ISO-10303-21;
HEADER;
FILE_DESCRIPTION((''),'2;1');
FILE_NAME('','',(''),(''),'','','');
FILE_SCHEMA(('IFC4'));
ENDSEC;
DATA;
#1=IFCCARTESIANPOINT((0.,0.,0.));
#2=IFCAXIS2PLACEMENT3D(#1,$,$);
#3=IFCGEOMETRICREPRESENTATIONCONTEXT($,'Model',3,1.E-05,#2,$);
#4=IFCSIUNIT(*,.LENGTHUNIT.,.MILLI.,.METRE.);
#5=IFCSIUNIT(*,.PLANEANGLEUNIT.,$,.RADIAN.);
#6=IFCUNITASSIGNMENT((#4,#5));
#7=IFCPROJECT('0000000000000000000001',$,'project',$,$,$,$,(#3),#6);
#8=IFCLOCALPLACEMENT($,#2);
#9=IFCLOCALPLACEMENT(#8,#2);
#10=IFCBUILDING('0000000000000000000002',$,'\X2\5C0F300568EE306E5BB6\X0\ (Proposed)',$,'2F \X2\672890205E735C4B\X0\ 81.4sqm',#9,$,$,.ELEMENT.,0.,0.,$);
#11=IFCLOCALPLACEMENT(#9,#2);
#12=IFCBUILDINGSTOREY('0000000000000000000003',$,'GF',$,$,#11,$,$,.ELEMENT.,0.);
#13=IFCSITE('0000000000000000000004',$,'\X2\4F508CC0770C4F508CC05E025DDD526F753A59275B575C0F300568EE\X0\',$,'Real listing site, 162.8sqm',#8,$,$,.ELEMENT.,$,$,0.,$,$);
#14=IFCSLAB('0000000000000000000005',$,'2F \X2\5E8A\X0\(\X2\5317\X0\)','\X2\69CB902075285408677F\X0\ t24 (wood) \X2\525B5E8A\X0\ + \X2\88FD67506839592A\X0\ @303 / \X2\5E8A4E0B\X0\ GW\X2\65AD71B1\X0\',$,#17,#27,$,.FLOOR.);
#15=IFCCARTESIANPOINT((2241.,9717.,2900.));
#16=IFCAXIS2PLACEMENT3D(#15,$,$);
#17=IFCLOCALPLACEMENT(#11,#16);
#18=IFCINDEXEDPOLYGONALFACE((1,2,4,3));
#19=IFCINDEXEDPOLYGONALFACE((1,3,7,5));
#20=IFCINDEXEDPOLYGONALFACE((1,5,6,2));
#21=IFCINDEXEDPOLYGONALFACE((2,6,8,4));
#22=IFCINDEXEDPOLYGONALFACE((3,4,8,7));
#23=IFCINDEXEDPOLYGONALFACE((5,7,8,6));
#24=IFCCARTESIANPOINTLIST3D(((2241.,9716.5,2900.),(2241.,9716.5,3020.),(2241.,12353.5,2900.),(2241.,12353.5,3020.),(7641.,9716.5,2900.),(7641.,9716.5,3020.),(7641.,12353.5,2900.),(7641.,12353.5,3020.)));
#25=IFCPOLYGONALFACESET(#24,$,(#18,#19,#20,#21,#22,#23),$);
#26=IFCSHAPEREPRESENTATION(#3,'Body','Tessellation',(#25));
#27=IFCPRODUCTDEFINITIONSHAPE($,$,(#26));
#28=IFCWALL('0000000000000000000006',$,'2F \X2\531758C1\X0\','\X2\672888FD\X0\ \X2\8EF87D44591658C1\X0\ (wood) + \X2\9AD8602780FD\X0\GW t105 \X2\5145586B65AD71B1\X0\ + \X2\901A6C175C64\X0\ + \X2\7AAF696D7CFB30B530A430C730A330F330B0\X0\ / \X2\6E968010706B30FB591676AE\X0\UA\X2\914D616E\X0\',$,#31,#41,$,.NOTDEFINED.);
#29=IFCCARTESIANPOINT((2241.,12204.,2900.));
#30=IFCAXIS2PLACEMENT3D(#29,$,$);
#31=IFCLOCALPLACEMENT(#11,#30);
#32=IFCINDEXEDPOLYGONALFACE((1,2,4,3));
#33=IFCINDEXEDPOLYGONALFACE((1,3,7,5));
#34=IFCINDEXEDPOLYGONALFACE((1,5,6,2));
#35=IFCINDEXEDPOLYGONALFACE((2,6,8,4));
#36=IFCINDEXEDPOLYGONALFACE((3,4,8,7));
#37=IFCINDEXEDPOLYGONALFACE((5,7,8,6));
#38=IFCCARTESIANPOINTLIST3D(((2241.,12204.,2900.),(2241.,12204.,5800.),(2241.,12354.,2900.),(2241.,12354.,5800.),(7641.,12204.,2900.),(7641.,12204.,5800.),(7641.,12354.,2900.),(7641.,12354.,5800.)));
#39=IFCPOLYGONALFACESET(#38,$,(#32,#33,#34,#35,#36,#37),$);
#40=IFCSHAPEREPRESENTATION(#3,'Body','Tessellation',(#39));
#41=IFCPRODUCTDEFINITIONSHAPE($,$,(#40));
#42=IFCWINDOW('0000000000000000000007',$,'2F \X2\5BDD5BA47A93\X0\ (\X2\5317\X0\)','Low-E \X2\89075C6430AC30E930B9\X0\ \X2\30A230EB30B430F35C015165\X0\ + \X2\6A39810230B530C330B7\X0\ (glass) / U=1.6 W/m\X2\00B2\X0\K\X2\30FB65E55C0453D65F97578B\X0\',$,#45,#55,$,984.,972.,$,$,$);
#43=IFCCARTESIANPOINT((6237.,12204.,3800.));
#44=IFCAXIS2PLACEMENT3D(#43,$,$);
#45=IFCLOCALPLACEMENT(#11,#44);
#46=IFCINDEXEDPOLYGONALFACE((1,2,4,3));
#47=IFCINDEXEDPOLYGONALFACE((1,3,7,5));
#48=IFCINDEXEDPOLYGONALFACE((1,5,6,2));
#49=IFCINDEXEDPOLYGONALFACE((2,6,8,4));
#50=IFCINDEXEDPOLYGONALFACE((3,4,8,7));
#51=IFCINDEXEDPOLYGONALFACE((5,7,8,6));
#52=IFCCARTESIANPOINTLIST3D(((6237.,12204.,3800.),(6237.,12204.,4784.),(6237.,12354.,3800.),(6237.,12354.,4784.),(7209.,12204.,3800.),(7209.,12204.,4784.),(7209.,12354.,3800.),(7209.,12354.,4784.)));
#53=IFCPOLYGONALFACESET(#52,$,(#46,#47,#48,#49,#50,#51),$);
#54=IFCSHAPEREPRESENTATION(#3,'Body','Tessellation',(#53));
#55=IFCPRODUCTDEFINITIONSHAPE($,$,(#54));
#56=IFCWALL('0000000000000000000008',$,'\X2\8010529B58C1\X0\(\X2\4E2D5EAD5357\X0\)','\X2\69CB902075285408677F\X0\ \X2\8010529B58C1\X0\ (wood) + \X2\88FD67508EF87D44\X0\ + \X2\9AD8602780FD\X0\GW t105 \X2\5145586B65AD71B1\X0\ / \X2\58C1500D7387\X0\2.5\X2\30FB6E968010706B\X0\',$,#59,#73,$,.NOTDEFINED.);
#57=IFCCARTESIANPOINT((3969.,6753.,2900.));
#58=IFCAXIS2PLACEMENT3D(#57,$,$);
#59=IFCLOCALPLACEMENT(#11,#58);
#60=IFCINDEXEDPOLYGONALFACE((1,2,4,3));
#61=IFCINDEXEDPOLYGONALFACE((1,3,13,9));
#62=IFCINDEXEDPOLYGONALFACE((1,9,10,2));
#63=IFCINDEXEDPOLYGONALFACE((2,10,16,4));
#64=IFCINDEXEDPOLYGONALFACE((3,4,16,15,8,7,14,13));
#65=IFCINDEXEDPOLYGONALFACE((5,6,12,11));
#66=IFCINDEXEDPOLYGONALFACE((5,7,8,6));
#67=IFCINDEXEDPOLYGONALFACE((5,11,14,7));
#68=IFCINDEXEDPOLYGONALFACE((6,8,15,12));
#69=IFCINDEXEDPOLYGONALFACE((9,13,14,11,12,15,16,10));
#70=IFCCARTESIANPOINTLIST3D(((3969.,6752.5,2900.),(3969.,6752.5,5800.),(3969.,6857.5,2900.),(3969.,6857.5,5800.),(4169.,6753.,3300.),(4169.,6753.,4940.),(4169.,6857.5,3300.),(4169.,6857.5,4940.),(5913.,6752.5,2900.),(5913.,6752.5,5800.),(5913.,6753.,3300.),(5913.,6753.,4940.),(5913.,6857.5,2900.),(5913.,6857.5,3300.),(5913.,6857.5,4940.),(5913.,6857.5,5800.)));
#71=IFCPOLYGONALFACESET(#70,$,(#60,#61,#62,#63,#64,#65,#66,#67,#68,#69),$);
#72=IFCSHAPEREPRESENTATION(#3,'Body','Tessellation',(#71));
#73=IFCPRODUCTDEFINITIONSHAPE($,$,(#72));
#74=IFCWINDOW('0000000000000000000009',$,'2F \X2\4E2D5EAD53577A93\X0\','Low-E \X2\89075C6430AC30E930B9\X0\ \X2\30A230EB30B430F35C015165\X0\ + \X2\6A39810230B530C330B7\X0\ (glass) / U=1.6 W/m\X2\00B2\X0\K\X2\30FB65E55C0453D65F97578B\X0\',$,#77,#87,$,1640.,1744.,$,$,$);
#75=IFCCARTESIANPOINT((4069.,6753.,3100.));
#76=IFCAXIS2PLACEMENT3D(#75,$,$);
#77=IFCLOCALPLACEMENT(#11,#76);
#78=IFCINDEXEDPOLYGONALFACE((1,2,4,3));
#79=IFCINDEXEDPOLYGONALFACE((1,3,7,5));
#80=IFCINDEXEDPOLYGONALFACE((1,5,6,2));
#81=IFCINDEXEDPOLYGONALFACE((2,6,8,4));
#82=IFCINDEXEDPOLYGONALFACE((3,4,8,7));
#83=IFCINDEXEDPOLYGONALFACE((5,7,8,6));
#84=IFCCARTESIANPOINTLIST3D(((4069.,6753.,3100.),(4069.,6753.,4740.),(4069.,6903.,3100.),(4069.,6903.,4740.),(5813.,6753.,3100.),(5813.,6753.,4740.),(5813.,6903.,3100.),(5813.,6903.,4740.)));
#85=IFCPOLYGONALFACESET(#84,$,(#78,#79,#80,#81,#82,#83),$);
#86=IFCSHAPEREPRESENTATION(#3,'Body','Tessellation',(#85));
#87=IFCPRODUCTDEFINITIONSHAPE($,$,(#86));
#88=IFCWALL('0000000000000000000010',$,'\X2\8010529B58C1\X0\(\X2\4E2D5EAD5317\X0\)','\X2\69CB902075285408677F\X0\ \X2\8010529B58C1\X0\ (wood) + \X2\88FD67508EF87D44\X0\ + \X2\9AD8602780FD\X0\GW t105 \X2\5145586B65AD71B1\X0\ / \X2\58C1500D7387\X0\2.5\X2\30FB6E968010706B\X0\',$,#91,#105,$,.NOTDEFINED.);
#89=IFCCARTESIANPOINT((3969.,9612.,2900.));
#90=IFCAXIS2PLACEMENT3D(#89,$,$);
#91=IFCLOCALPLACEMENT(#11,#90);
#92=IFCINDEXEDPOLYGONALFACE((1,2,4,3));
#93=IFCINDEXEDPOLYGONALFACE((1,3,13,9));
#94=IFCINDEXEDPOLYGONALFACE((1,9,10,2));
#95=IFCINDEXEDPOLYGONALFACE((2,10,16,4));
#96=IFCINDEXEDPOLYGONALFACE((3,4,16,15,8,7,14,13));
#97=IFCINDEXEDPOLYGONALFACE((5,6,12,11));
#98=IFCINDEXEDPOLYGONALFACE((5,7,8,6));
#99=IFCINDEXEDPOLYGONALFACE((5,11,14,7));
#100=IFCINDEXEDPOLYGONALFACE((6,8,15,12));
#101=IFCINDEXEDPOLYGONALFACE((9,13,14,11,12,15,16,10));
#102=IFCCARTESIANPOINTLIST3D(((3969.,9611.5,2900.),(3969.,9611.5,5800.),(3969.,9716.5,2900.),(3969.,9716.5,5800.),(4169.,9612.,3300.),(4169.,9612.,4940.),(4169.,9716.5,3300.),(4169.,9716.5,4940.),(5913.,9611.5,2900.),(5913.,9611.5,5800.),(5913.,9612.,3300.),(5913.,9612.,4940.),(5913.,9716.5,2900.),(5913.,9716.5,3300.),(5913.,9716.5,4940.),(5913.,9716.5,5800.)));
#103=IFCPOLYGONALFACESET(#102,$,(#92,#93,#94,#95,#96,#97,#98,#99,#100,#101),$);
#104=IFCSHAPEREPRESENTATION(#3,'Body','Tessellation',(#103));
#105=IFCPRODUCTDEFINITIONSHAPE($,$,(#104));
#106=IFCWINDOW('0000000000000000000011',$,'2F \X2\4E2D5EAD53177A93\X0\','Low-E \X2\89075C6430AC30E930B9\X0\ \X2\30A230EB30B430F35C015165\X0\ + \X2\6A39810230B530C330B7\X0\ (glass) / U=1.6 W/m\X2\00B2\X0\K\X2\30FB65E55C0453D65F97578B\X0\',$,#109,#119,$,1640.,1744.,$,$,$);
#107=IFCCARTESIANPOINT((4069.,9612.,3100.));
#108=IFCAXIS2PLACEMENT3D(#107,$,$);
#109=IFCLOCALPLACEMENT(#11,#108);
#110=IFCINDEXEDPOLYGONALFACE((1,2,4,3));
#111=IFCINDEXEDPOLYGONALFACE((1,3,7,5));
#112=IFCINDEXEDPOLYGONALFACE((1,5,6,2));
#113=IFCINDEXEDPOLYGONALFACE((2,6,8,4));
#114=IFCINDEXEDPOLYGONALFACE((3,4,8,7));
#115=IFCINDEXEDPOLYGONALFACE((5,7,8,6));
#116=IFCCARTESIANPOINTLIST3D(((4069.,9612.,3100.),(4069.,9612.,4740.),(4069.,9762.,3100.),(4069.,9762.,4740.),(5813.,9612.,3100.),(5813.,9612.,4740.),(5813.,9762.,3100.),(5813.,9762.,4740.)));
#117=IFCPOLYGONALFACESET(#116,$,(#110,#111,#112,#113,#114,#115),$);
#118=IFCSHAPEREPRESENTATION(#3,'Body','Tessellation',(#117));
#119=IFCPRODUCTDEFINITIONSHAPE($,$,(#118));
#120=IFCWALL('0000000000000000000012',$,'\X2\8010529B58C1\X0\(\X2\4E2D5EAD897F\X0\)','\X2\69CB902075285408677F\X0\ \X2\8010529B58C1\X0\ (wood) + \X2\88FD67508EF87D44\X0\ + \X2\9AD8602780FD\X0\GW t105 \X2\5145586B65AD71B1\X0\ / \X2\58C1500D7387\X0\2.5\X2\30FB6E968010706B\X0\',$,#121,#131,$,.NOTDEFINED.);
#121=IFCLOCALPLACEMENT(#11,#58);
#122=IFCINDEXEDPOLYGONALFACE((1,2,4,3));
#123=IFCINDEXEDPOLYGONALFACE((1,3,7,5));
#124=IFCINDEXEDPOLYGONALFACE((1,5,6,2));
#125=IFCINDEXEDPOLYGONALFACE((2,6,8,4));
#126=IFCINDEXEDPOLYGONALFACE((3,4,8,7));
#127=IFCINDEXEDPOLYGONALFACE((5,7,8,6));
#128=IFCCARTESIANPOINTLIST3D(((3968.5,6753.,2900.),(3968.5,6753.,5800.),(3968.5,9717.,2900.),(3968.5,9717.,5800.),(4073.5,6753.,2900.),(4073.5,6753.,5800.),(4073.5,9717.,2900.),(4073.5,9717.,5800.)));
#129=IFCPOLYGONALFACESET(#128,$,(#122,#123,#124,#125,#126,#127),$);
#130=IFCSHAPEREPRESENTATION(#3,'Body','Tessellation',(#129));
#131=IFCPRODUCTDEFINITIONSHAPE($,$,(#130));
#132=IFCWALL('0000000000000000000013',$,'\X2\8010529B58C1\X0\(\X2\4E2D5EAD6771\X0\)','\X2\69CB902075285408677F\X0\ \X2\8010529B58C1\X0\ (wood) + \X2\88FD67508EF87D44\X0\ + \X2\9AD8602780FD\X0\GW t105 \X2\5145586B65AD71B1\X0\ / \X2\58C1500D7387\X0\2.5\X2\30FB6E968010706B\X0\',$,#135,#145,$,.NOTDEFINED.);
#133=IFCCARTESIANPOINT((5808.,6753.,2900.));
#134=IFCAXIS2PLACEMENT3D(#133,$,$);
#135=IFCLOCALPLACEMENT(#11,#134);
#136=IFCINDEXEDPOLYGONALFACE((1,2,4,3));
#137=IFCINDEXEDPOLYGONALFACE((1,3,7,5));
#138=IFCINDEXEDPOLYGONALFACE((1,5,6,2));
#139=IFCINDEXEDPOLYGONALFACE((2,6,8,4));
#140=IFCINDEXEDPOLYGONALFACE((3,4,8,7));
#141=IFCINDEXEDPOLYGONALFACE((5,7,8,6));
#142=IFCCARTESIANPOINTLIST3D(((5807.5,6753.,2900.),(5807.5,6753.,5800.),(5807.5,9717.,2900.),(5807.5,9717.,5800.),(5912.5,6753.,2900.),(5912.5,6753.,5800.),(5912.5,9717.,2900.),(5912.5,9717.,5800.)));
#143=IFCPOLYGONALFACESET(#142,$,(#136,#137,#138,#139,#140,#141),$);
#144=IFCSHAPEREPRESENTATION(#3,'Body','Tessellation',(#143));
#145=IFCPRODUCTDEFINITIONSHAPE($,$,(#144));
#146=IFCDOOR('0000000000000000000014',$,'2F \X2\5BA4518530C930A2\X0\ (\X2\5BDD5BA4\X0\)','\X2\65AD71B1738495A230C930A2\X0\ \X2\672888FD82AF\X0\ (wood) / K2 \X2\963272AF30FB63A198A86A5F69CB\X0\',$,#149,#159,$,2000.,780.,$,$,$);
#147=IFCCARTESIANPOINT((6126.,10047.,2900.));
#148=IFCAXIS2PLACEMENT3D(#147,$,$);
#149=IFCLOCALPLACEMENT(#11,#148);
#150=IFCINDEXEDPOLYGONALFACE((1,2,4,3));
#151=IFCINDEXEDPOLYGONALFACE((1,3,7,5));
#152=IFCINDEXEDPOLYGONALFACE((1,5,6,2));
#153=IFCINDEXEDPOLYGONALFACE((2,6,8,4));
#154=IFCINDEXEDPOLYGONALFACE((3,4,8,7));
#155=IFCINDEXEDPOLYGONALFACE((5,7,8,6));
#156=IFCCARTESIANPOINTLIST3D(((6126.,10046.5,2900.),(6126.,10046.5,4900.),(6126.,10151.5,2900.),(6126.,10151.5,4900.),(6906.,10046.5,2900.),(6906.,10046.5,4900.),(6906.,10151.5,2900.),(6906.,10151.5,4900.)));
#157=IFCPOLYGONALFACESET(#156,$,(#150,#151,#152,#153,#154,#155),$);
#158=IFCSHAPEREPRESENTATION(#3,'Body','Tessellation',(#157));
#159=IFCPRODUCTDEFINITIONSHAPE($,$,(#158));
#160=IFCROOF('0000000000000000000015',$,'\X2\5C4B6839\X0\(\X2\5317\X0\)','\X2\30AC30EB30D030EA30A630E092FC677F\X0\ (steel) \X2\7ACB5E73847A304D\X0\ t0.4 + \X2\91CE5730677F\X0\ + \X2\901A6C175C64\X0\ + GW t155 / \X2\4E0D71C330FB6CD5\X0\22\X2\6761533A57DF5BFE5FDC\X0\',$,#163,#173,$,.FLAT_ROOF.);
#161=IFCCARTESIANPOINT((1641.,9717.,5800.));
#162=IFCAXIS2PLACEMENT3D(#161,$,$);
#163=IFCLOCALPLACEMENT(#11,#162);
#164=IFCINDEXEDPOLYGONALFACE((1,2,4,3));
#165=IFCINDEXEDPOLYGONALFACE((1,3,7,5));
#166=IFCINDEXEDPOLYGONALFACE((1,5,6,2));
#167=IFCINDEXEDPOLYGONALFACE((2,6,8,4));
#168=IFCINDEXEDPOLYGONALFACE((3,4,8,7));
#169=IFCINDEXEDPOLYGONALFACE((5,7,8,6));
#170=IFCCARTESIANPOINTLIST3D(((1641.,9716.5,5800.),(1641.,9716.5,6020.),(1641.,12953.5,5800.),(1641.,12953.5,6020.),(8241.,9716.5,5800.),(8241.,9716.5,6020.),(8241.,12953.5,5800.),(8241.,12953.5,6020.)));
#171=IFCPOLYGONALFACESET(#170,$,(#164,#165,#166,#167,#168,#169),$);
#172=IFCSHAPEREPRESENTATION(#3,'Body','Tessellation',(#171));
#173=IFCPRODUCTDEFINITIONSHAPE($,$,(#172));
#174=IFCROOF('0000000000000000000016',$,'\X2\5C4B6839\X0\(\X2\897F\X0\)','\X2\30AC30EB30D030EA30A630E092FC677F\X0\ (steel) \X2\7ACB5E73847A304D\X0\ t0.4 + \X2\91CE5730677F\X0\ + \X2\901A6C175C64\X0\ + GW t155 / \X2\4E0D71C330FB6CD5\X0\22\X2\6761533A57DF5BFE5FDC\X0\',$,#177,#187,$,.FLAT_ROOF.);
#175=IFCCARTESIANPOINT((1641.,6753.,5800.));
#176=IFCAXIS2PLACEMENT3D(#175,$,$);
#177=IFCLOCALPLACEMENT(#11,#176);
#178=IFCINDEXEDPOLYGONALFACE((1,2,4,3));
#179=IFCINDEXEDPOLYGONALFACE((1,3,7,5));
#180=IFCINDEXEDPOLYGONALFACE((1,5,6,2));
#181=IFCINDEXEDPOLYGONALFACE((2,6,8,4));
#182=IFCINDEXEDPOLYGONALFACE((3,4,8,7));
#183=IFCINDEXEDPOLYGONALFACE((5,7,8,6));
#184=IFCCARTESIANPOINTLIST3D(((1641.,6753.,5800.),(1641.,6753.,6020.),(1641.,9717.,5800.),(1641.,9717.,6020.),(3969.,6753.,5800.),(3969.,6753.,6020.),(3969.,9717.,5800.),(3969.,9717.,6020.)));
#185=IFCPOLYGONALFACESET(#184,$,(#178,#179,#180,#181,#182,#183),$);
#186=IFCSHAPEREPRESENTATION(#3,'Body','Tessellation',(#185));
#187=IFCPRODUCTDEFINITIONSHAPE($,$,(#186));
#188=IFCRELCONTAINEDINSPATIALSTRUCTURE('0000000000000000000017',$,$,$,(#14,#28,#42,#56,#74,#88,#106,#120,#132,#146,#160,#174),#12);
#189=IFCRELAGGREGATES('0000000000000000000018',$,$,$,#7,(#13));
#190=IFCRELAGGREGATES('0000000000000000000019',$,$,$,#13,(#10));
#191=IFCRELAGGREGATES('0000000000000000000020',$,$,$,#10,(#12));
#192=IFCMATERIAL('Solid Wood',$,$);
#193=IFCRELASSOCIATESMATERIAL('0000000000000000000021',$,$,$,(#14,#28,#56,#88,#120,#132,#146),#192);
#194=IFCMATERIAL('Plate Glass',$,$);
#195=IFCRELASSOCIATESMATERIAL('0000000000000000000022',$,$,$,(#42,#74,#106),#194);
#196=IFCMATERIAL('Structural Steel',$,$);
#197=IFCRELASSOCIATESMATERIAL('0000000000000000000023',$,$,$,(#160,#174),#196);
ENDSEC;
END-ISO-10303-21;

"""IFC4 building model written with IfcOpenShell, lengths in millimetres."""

from ifc_helpers import new_model, si_unit, frame, frame_2d, origin, place, context, project, spatial, rectangle, extrude, material, element, fill, save


model = new_model("IFC4")

# Units and contexts
model_context = context("Model", 3, precision=1e-05, world=origin())
ifc_project = project(units=[si_unit("LENGTHUNIT", "METRE", prefix="MILLI"), si_unit("PLANEANGLEUNIT", "RADIAN")], contexts=[model_context])

# Site, building, storey
site_placement = place(None, origin())
site = spatial("IfcSite", under=ifc_project, at=site_placement, Name="佐賀県佐賀市川副町大字小々森", ObjectType="Real listing site, 162.8sqm", CompositionType="ELEMENT", RefElevation=0.0)
building_placement = place(site_placement, origin())
building = spatial("IfcBuilding", under=site, at=building_placement, Name="小々森の家 (Proposed)", ObjectType="2F 木造平屋 81.4sqm", CompositionType="ELEMENT", ElevationOfRefHeight=0.0, ElevationOfTerrain=0.0)
storey_placement = place(building_placement, origin())
storey = spatial("IfcBuildingStorey", under=building, at=storey_placement, Name="GF", CompositionType="ELEMENT", Elevation=0.0)

# Slab
ifc_material_1 = material(Name="Solid Wood")
slab_placement = place(storey_placement, frame((2241.0, 9717.0, 2900.0)))
element("IfcSlab", 1, at=slab_placement, inside=storey, material=ifc_material_1, Name="2F 床(北)", Description="構造用合板 t24 (wood) 剛床 + 製材根太 @303 / 床下 GW断熱", PredefinedType="FLOOR", context=model_context, shape_type="SweptSolid", body=[
    extrude(rectangle(XDim=5400.0, YDim=2637.0, at=frame_2d((2700.0, 1318.0))), frame((2241.0, 9717.0, 2900.0)), (0.0, 0.0, 1.0), 120.0),
])

# Walls, openings, windows
wall_1_placement = place(storey_placement, frame((2241.0, 12204.0, 2900.0)))
wall_1 = element("IfcWall", 2, at=wall_1_placement, inside=storey, material=ifc_material_1, Name="2F 北壁", Description="木製 軸組外壁 (wood) + 高性能GW t105 充填断熱 + 通気層 + 窯業系サイディング / 準耐火・外皮UA配慮", PredefinedType="NOTDEFINED", context=model_context, shape_type="SweptSolid", body=[
    extrude(rectangle(XDim=5400.0, YDim=150.0, at=frame_2d((2700.0, 75.0))), frame((2241.0, 12204.0, 2900.0)), (0.0, 0.0, 1.0), 2900.0),
])
opening_1_placement = place(storey_placement, frame((6237.0, 12204.0, 3800.0)))
opening_1 = element("IfcOpeningElement", 3, at=opening_1_placement, cuts=wall_1, PredefinedType="NOTDEFINED", context=model_context, shape_type="SweptSolid", body=[
    extrude(rectangle(XDim=972.0, YDim=150.0, at=frame_2d((486.0, 75.0))), frame((6237.0, 12204.0, 3800.0)), (0.0, 0.0, 1.0), 984.0),
])
ifc_material_2 = material(Name="Plate Glass")
window_1_placement = place(storey_placement, frame((6237.0, 12204.0, 3800.0)))
window_1 = element("IfcWindow", 4, at=window_1_placement, inside=storey, material=ifc_material_2, Name="2F 寝室窓 (北)", Description="Low-E 複層ガラス アルゴン封入 + 樹脂サッシ (glass) / U=1.6 W/m²K・日射取得型", OverallHeight=984.0, OverallWidth=972.0, context=model_context, shape_type="SweptSolid", body=[
    extrude(rectangle(XDim=972.0, YDim=150.0, at=frame_2d((486.0, 75.0))), frame((6237.0, 12204.0, 3800.0)), (0.0, 0.0, 1.0), 984.0),
])
fill(opening_1, window_1)
wall_2_placement = place(storey_placement, frame((3969.0, 6753.0, 2900.0)))
wall_2 = element("IfcWall", 5, at=wall_2_placement, inside=storey, material=ifc_material_1, Name="耐力壁(中庭南)", Description="構造用合板 耐力壁 (wood) + 製材軸組 + 高性能GW t105 充填断熱 / 壁倍率2.5・準耐火", PredefinedType="NOTDEFINED", context=model_context, shape_type="SweptSolid", body=[
    extrude(rectangle(XDim=1944.0, YDim=105.0, at=frame_2d((972.0, 52.0))), frame((3969.0, 6753.0, 2900.0)), (0.0, 0.0, 1.0), 2900.0),
])
opening_2_placement = place(storey_placement, frame((4069.0, 6753.0, 3100.0)))
opening_2 = element("IfcOpeningElement", 6, at=opening_2_placement, cuts=wall_2, PredefinedType="NOTDEFINED", context=model_context, shape_type="SweptSolid", body=[
    extrude(rectangle(XDim=1744.0, YDim=150.0, at=frame_2d((872.0, 75.0))), frame((4069.0, 6753.0, 3100.0)), (0.0, 0.0, 1.0), 1640.0),
])
window_2_placement = place(storey_placement, frame((4069.0, 6753.0, 3100.0)))
window_2 = element("IfcWindow", 7, at=window_2_placement, inside=storey, material=ifc_material_2, Name="2F 中庭南窓", Description="Low-E 複層ガラス アルゴン封入 + 樹脂サッシ (glass) / U=1.6 W/m²K・日射取得型", OverallHeight=1640.0, OverallWidth=1744.0, context=model_context, shape_type="SweptSolid", body=[
    extrude(rectangle(XDim=1744.0, YDim=150.0, at=frame_2d((872.0, 75.0))), frame((4069.0, 6753.0, 3100.0)), (0.0, 0.0, 1.0), 1640.0),
])
fill(opening_2, window_2)
wall_3_placement = place(storey_placement, frame((3969.0, 9612.0, 2900.0)))
wall_3 = element("IfcWall", 8, at=wall_3_placement, inside=storey, material=ifc_material_1, Name="耐力壁(中庭北)", Description="構造用合板 耐力壁 (wood) + 製材軸組 + 高性能GW t105 充填断熱 / 壁倍率2.5・準耐火", PredefinedType="NOTDEFINED", context=model_context, shape_type="SweptSolid", body=[
    extrude(rectangle(XDim=1944.0, YDim=105.0, at=frame_2d((972.0, 52.0))), frame((3969.0, 9612.0, 2900.0)), (0.0, 0.0, 1.0), 2900.0),
])
opening_3_placement = place(storey_placement, frame((4069.0, 9612.0, 3100.0)))
opening_3 = element("IfcOpeningElement", 9, at=opening_3_placement, cuts=wall_3, PredefinedType="NOTDEFINED", context=model_context, shape_type="SweptSolid", body=[
    extrude(rectangle(XDim=1744.0, YDim=150.0, at=frame_2d((872.0, 75.0))), frame((4069.0, 9612.0, 3100.0)), (0.0, 0.0, 1.0), 1640.0),
])
window_3_placement = place(storey_placement, frame((4069.0, 9612.0, 3100.0)))
window_3 = element("IfcWindow", 10, at=window_3_placement, inside=storey, material=ifc_material_2, Name="2F 中庭北窓", Description="Low-E 複層ガラス アルゴン封入 + 樹脂サッシ (glass) / U=1.6 W/m²K・日射取得型", OverallHeight=1640.0, OverallWidth=1744.0, context=model_context, shape_type="SweptSolid", body=[
    extrude(rectangle(XDim=1744.0, YDim=150.0, at=frame_2d((872.0, 75.0))), frame((4069.0, 9612.0, 3100.0)), (0.0, 0.0, 1.0), 1640.0),
])
fill(opening_3, window_3)

# Walls
wall_4_placement = place(storey_placement, frame((3969.0, 6753.0, 2900.0)))
element("IfcWall", 11, at=wall_4_placement, inside=storey, material=ifc_material_1, Name="耐力壁(中庭西)", Description="構造用合板 耐力壁 (wood) + 製材軸組 + 高性能GW t105 充填断熱 / 壁倍率2.5・準耐火", PredefinedType="NOTDEFINED", context=model_context, shape_type="SweptSolid", body=[
    extrude(rectangle(XDim=105.0, YDim=2964.0, at=frame_2d((52.0, 1482.0))), frame((3969.0, 6753.0, 2900.0)), (0.0, 0.0, 1.0), 2900.0),
])
wall_5_placement = place(storey_placement, frame((5808.0, 6753.0, 2900.0)))
element("IfcWall", 12, at=wall_5_placement, inside=storey, material=ifc_material_1, Name="耐力壁(中庭東)", Description="構造用合板 耐力壁 (wood) + 製材軸組 + 高性能GW t105 充填断熱 / 壁倍率2.5・準耐火", PredefinedType="NOTDEFINED", context=model_context, shape_type="SweptSolid", body=[
    extrude(rectangle(XDim=105.0, YDim=2964.0, at=frame_2d((52.0, 1482.0))), frame((5808.0, 6753.0, 2900.0)), (0.0, 0.0, 1.0), 2900.0),
])

# Door
door_placement = place(storey_placement, frame((6126.0, 10047.0, 2900.0)))
element("IfcDoor", 13, at=door_placement, inside=storey, material=ifc_material_1, Name="2F 室内ドア (寝室)", Description="断熱玄関ドア 木製芯 (wood) / K2 防犯・採風機構", OverallHeight=2000.0, OverallWidth=780.0, context=model_context, shape_type="SweptSolid", body=[
    extrude(rectangle(XDim=780.0, YDim=105.0, at=frame_2d((390.0, 52.0))), frame((6126.0, 10047.0, 2900.0)), (0.0, 0.0, 1.0), 2000.0),
])

# Roofs
ifc_material_3 = material(Name="Structural Steel")
for number, where, name in (
    (14, (1641.0, 9717.0, 5800.0), "屋根(北)"),
):
    element("IfcRoof", number, at=place(storey_placement, frame(where)), inside=storey, material=ifc_material_3, Name=name, Description="ガルバリウム鋼板 (steel) 立平葺き t0.4 + 野地板 + 通気層 + GW t155 / 不燃・法22条区域対応", PredefinedType="FLAT_ROOF", context=model_context, shape_type="SweptSolid", body=[
        extrude(rectangle(XDim=6600.0, YDim=3237.0, at=frame_2d((3300.0, 1618.0))), frame((1641.0, 9717.0, 5800.0)), (0.0, 0.0, 1.0), 220.0),
    ])
roof_1_placement = place(storey_placement, frame((1641.0, 6753.0, 5800.0)))
element("IfcRoof", 15, at=roof_1_placement, inside=storey, material=ifc_material_3, Name="屋根(西)", Description="ガルバリウム鋼板 (steel) 立平葺き t0.4 + 野地板 + 通気層 + GW t155 / 不燃・法22条区域対応", PredefinedType="FLAT_ROOF", context=model_context, shape_type="SweptSolid", body=[
    extrude(rectangle(XDim=2328.0, YDim=2964.0, at=frame_2d((1164.0, 1482.0))), frame((1641.0, 6753.0, 5800.0)), (0.0, 0.0, 1.0), 220.0),
])

save(model, "model.ifc")
